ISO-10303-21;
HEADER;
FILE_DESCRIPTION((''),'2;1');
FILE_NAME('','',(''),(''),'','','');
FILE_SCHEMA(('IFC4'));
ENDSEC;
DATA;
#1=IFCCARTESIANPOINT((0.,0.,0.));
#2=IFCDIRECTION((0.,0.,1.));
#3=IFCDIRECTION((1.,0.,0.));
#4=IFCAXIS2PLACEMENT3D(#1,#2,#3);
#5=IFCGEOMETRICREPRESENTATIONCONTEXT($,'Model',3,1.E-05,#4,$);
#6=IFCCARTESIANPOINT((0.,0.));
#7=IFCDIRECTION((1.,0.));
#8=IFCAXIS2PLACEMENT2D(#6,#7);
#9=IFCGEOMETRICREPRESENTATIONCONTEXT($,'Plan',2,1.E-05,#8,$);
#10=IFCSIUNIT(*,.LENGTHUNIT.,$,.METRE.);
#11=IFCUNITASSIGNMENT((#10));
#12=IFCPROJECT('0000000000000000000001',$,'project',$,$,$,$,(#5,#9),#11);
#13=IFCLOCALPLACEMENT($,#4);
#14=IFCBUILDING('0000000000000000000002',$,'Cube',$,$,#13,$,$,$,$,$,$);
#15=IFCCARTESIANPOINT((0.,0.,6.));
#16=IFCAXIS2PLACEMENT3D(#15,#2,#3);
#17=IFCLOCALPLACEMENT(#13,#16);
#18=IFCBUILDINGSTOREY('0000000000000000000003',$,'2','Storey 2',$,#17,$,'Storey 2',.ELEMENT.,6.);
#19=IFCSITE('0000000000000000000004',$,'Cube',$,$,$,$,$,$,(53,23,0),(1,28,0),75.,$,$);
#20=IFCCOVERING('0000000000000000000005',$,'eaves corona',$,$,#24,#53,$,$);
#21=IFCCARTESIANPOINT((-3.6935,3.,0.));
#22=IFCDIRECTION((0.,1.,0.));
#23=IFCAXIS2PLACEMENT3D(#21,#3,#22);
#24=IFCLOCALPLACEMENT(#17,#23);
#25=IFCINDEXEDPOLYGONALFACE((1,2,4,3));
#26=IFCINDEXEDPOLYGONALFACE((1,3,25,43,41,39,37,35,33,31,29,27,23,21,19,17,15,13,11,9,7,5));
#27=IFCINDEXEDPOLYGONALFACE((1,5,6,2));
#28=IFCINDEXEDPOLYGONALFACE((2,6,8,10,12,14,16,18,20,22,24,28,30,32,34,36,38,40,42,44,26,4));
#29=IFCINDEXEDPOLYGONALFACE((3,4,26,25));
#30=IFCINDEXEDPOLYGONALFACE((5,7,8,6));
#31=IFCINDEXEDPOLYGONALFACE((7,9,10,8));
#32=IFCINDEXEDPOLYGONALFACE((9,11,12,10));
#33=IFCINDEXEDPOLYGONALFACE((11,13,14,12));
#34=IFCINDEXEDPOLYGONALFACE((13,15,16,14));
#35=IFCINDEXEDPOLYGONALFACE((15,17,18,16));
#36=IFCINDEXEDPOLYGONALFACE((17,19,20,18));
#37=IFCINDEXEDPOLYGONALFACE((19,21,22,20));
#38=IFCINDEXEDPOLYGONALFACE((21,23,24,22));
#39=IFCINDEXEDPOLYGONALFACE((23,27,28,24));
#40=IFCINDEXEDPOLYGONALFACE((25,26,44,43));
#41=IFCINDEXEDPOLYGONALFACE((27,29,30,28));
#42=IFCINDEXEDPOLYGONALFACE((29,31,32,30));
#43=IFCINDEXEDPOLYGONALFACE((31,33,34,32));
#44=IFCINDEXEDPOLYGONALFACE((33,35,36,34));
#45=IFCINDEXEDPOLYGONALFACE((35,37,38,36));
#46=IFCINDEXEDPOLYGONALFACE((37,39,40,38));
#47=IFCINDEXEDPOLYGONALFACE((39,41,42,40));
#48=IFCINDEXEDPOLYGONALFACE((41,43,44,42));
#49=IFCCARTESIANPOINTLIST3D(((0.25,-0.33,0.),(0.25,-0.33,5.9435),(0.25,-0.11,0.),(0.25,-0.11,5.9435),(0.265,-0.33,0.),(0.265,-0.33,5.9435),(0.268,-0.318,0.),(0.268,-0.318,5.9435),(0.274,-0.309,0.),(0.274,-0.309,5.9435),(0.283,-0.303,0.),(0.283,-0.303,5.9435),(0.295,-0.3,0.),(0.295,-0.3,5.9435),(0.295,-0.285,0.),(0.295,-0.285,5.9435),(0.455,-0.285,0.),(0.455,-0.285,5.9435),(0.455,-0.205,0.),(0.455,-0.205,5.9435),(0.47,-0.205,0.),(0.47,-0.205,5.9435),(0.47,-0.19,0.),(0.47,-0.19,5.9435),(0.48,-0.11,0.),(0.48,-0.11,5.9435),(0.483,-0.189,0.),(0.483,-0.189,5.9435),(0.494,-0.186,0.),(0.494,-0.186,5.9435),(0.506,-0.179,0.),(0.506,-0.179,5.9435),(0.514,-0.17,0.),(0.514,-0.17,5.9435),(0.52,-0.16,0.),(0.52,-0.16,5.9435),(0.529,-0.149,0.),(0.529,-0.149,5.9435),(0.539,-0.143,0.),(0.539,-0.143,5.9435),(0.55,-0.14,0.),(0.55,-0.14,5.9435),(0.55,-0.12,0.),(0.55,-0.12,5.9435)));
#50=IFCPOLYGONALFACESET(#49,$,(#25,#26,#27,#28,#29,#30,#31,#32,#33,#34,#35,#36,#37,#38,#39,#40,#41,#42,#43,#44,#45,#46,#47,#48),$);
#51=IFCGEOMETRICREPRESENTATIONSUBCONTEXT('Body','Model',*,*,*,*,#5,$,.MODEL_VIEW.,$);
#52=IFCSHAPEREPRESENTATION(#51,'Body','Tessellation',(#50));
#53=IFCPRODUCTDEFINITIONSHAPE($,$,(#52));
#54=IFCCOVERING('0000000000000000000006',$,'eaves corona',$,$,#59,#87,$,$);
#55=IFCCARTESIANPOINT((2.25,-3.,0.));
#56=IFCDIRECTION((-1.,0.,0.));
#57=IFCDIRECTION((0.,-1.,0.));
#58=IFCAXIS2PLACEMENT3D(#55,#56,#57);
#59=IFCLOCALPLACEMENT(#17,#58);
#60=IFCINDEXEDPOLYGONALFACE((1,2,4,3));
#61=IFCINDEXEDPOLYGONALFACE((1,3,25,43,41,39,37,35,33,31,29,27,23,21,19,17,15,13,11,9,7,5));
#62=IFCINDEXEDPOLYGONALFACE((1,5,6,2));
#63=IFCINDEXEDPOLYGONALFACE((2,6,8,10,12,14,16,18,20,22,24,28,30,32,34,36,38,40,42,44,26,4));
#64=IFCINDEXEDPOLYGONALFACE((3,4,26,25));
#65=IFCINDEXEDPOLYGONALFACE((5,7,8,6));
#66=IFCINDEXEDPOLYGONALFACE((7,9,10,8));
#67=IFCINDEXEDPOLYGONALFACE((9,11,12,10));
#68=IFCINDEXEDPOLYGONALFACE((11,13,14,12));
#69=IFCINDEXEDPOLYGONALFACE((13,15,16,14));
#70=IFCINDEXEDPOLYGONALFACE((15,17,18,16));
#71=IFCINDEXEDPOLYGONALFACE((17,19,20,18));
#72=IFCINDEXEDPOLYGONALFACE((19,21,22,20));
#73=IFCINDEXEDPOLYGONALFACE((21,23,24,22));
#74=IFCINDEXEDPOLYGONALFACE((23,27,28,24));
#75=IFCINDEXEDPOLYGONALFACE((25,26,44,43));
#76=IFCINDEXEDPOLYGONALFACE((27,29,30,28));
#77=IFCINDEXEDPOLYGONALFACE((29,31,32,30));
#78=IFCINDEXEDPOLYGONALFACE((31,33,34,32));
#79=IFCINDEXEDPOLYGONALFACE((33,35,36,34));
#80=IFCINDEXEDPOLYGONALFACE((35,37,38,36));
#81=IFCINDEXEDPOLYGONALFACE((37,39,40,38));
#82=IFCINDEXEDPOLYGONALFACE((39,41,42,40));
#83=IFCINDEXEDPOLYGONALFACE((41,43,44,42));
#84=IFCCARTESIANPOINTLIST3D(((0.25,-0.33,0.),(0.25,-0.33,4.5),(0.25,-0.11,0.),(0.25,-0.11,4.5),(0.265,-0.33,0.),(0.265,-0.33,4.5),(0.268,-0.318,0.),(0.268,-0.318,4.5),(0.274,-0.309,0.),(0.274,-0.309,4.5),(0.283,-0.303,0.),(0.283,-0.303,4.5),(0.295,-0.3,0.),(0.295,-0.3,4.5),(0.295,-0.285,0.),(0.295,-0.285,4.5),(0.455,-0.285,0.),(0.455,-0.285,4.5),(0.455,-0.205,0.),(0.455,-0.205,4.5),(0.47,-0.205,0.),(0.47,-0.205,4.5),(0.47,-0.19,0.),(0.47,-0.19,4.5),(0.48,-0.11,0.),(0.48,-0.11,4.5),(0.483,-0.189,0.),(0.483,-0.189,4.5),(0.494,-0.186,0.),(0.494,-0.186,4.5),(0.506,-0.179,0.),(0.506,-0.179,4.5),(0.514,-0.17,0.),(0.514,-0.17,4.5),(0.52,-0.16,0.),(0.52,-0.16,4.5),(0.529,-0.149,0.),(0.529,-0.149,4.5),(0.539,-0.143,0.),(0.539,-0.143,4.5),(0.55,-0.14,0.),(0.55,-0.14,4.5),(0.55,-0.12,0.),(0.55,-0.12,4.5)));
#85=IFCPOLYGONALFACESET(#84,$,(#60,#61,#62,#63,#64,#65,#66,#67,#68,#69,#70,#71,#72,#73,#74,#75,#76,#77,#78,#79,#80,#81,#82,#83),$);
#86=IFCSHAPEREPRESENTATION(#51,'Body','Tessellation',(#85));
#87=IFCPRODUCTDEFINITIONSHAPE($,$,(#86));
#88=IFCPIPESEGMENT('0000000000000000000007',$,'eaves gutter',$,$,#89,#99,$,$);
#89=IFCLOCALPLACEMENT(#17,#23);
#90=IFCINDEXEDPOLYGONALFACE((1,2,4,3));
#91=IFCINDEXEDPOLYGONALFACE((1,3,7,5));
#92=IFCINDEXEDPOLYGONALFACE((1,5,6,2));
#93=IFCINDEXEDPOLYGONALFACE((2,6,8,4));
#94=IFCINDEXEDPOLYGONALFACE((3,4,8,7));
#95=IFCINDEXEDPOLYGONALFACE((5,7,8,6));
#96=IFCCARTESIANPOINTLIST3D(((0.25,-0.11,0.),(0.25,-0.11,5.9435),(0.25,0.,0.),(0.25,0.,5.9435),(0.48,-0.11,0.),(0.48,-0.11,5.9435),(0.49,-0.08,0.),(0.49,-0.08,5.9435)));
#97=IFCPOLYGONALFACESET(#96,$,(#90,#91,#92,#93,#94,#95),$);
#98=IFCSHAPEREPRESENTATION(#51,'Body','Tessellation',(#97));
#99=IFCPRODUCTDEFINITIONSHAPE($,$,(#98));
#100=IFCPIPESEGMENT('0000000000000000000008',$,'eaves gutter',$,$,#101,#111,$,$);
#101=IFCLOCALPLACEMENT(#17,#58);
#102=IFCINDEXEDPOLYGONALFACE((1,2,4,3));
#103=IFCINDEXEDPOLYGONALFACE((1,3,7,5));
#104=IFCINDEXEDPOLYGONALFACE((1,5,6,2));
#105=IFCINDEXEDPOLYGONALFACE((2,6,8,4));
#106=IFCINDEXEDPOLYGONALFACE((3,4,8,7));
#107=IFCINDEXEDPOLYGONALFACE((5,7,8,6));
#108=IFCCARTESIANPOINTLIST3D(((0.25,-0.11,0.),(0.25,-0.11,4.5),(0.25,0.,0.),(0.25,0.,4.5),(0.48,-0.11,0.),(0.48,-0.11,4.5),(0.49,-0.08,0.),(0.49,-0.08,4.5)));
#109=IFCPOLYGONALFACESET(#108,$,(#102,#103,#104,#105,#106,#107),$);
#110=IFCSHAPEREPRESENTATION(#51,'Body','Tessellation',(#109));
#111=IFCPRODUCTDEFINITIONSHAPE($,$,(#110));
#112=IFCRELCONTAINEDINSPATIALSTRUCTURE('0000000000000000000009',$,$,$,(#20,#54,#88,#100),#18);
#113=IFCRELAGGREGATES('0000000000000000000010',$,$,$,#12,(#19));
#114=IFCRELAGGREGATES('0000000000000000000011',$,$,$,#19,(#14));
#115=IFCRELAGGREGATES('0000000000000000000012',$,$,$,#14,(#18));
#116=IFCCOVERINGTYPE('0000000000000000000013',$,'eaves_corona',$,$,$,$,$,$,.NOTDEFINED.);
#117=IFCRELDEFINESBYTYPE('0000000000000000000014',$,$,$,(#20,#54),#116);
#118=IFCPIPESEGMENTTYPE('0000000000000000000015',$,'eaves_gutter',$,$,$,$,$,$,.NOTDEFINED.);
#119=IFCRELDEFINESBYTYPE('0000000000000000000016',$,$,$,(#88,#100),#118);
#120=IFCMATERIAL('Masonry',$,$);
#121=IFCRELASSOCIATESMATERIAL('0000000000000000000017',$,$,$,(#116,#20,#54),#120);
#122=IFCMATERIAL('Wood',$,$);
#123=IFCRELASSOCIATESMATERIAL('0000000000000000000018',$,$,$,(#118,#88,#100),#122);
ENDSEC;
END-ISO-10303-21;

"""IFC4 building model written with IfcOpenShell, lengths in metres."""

from ifc_helpers import new_model, si_unit, frame, origin_with_axes, origin_2d_with_axis, place, context, subcontext, project, spatial, polyline, outline, extrude, material, material_profile, profile_set, profile_usage, type_object, element, save


model = new_model("IFC4")

# Units and contexts
model_context = context("Model", 3, precision=1e-05, world=origin_with_axes())
plan_context = context("Plan", 2, precision=1e-05, world=origin_2d_with_axis())
body_context = subcontext(model_context, "Body", "Model", "MODEL_VIEW")
ifc_project = project(units=[si_unit("LENGTHUNIT", "METRE")], contexts=[model_context, plan_context])

# Site, building, storey
site = spatial("IfcSite", under=ifc_project, Name="Cube", RefLatitude=(53, 23, 0), RefLongitude=(1, 28, 0), RefElevation=75.0)
building_placement = place(None, origin_with_axes())
building = spatial("IfcBuilding", under=site, at=building_placement, Name="Cube")
storey_placement = place(building_placement, frame((0.0, 0.0, 6.0), z_axis=(0.0, 0.0, 1.0), x_axis=(1.0, 0.0, 0.0)))
storey = spatial("IfcBuildingStorey", under=building, at=storey_placement, Name="2", Description="Storey 2", LongName="Storey 2", CompositionType="ELEMENT", Elevation=6.0)

# Coverings
ifc_material_1 = material(Name="Masonry")
ifc_material_profile_1 = material_profile(ifc_material_1, outline(polyline([(0.25, -0.11), (0.25, -0.33), (0.265, -0.33), (0.268, -0.318), (0.274, -0.309), (0.283, -0.303), (0.295, -0.3), (0.295, -0.285), (0.455, -0.285), (0.455, -0.205), (0.47, -0.205), (0.47, -0.19), (0.483, -0.189), (0.494, -0.186), (0.506, -0.179), (0.514, -0.17), (0.52, -0.16), (0.529, -0.149), (0.539, -0.143), (0.55, -0.14), (0.55, -0.12), (0.48, -0.11), (0.25, -0.11)])))
ifc_profile_set_1 = profile_set([ifc_material_profile_1])
ifc_profile_usage_1 = profile_usage(ifc_profile_set_1)
covering_type_1 = type_object("IfcCoveringType", Name="eaves_corona", PredefinedType="NOTDEFINED", material=ifc_profile_set_1)
covering_1_placement = place(storey_placement, frame((-3.6935, 3.0, 0.0), z_axis=(1.0, 0.0, 0.0), x_axis=(0.0, 1.0, 0.0)))
element("IfcCovering", 1, at=covering_1_placement, inside=storey, type_object=covering_type_1, material=ifc_profile_usage_1, Name="eaves corona", context=body_context, shape_type="SweptSolid", body=[
    extrude(outline(polyline([(0.25, -0.11), (0.25, -0.33), (0.265, -0.33), (0.268, -0.318), (0.274, -0.309), (0.283, -0.303), (0.295, -0.3), (0.295, -0.285), (0.455, -0.285), (0.455, -0.205), (0.47, -0.205), (0.47, -0.19), (0.483, -0.189), (0.494, -0.186), (0.506, -0.179), (0.514, -0.17), (0.52, -0.16), (0.529, -0.149), (0.539, -0.143), (0.55, -0.14), (0.55, -0.12), (0.48, -0.11), (0.25, -0.11)])), origin_with_axes(), (0.0, 0.0, 1.0), 5.9435),
])
ifc_profile_usage_2 = profile_usage(ifc_profile_set_1)
covering_2_placement = place(storey_placement, frame((2.25, -3.0, 0.0), z_axis=(-1.0, 0.0, 0.0), x_axis=(0.0, -1.0, 0.0)))
element("IfcCovering", 2, at=covering_2_placement, inside=storey, type_object=covering_type_1, material=ifc_profile_usage_2, Name="eaves corona", context=body_context, shape_type="SweptSolid", body=[
    extrude(outline(polyline([(0.25, -0.11), (0.25, -0.33), (0.265, -0.33), (0.268, -0.318), (0.274, -0.309), (0.283, -0.303), (0.295, -0.3), (0.295, -0.285), (0.455, -0.285), (0.455, -0.205), (0.47, -0.205), (0.47, -0.19), (0.483, -0.189), (0.494, -0.186), (0.506, -0.179), (0.514, -0.17), (0.52, -0.16), (0.529, -0.149), (0.539, -0.143), (0.55, -0.14), (0.55, -0.12), (0.48, -0.11), (0.25, -0.11)])), origin_with_axes(), (0.0, 0.0, 1.0), 4.5),
])

# Pipe segments
ifc_material_2 = material(Name="Wood")
ifc_material_profile_2 = material_profile(ifc_material_2, outline(polyline([(0.25, -0.11), (0.48, -0.11), (0.49, -0.08), (0.25, 0.0), (0.25, -0.11)])))
ifc_profile_set_2 = profile_set([ifc_material_profile_2])
ifc_profile_usage_3 = profile_usage(ifc_profile_set_2)
pipe_segment_type = type_object("IfcPipeSegmentType", Name="eaves_gutter", PredefinedType="NOTDEFINED", material=ifc_profile_set_2)
pipe_segment_1_placement = place(storey_placement, frame((-3.6935, 3.0, 0.0), z_axis=(1.0, 0.0, 0.0), x_axis=(0.0, 1.0, 0.0)))
element("IfcPipeSegment", 3, at=pipe_segment_1_placement, inside=storey, type_object=pipe_segment_type, material=ifc_profile_usage_3, Name="eaves gutter", context=body_context, shape_type="SweptSolid", body=[
    extrude(outline(polyline([(0.25, -0.11), (0.48, -0.11), (0.49, -0.08), (0.25, 0.0), (0.25, -0.11)])), origin_with_axes(), (0.0, 0.0, 1.0), 5.9435),
])
ifc_profile_usage_4 = profile_usage(ifc_profile_set_2)
pipe_segment_2_placement = place(storey_placement, frame((2.25, -3.0, 0.0), z_axis=(-1.0, 0.0, 0.0), x_axis=(0.0, -1.0, 0.0)))
element("IfcPipeSegment", 4, at=pipe_segment_2_placement, inside=storey, type_object=pipe_segment_type, material=ifc_profile_usage_4, Name="eaves gutter", context=body_context, shape_type="SweptSolid", body=[
    extrude(outline(polyline([(0.25, -0.11), (0.48, -0.11), (0.49, -0.08), (0.25, 0.0), (0.25, -0.11)])), origin_with_axes(), (0.0, 0.0, 1.0), 4.5),
])

save(model, "model.ifc")
